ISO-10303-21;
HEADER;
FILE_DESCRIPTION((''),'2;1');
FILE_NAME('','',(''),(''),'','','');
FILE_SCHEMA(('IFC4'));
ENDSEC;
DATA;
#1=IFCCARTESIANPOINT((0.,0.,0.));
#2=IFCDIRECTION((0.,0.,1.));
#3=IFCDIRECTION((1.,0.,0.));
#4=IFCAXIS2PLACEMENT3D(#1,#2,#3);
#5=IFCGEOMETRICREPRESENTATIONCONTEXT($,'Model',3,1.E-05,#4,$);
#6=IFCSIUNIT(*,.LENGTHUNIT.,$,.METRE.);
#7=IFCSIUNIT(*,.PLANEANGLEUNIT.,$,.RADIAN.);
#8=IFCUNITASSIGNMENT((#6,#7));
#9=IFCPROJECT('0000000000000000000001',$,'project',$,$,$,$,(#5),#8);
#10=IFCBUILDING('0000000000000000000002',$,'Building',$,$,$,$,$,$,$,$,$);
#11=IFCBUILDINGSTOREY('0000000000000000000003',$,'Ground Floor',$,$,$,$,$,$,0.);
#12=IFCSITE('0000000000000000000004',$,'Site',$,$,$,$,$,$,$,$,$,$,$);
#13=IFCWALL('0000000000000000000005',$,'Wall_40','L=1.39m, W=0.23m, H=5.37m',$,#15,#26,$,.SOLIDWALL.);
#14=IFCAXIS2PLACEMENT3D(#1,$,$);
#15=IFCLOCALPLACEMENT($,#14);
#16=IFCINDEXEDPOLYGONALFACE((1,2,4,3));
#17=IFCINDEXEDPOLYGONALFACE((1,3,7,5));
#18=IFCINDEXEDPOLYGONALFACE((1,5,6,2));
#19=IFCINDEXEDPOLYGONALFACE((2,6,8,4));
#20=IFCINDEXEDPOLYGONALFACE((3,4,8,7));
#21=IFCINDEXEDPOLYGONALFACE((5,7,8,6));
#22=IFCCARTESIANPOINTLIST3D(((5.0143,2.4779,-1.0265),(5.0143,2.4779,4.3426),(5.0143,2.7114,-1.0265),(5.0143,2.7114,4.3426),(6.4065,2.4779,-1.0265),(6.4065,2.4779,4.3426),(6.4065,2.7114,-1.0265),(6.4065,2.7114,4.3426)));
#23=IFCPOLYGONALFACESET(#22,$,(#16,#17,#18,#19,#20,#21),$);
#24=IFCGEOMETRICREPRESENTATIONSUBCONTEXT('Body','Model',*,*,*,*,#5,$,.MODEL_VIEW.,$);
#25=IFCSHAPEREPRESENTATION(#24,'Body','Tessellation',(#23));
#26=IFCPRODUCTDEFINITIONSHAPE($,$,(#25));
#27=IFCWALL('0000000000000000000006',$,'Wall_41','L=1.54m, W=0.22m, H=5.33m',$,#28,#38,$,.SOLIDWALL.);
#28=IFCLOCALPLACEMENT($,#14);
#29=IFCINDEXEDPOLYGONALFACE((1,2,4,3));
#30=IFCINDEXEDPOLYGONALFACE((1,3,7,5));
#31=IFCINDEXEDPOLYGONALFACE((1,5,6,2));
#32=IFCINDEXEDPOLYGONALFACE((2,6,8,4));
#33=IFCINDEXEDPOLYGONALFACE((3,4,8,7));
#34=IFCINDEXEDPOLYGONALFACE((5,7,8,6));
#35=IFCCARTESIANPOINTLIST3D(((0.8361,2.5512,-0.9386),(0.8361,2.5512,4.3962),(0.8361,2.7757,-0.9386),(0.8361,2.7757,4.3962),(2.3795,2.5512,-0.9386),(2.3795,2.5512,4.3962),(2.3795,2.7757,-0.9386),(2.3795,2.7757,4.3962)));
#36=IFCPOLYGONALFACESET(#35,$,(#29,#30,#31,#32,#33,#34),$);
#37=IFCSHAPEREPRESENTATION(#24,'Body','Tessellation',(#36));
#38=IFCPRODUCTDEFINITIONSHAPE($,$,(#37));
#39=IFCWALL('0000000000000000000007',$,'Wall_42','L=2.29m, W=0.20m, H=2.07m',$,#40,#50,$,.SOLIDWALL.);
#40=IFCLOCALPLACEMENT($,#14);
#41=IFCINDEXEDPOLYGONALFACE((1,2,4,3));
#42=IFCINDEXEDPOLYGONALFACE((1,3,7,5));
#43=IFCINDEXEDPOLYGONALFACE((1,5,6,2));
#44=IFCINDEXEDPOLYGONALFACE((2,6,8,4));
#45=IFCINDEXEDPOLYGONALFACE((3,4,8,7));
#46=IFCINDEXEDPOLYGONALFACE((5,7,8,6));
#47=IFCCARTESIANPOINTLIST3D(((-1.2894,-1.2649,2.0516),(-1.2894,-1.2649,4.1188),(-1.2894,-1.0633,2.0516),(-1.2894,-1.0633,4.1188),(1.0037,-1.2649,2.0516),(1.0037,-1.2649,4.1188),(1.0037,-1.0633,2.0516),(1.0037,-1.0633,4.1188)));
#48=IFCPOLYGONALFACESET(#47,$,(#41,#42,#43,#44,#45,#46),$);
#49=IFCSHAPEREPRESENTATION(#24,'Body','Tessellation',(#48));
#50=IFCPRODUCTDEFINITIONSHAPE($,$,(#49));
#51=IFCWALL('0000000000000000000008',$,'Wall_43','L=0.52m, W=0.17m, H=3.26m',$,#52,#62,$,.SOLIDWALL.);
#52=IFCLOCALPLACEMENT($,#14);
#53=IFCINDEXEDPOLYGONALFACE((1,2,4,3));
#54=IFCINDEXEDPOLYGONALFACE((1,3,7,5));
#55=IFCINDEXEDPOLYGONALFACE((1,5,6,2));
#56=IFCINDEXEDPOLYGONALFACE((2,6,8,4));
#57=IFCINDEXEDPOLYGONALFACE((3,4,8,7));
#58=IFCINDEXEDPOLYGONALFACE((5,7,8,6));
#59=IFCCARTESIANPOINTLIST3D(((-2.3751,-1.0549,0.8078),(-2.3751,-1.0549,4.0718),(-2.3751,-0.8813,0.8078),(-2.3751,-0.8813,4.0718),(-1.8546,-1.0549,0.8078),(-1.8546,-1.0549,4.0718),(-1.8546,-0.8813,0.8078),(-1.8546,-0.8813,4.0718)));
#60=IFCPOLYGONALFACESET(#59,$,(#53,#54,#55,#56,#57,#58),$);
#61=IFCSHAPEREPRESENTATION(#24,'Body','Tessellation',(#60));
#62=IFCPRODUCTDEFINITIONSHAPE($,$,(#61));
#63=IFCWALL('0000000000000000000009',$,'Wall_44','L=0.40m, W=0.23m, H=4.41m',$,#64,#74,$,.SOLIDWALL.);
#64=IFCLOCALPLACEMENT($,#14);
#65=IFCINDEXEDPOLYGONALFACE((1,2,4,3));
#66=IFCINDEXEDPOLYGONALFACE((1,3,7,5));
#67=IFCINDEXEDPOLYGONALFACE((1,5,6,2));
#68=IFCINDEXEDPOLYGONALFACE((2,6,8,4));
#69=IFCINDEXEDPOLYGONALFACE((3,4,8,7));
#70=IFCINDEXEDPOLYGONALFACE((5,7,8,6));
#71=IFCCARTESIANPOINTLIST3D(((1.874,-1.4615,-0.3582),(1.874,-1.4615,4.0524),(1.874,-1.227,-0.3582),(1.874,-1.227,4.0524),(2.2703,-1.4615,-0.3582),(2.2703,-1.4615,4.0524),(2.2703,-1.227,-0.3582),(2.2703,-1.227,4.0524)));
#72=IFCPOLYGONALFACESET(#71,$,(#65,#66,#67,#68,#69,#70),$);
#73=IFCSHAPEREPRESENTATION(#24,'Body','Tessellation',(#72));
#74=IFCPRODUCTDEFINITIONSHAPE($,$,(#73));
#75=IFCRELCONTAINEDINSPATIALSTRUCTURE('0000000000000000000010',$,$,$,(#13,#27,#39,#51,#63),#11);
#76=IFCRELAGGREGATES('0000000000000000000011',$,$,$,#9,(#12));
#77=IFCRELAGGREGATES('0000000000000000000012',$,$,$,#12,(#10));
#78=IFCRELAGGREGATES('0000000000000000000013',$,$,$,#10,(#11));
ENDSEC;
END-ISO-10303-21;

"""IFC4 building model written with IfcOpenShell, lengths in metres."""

from ifc_helpers import new_model, si_unit, frame, origin_with_axes, origin_2d, context, subcontext, project, spatial, rectangle, extrude, element, save


model = new_model("IFC4")

# Units and contexts
model_context = context("Model", 3, precision=1e-05, world=origin_with_axes())
body_context = subcontext(model_context, "Body", "Model", "MODEL_VIEW")
ifc_project = project(units=[si_unit("LENGTHUNIT", "METRE"), si_unit("PLANEANGLEUNIT", "RADIAN")], contexts=[model_context])

# Site, building, storey
site = spatial("IfcSite", under=ifc_project, Name="Site")
building = spatial("IfcBuilding", under=site, Name="Building")
storey = spatial("IfcBuildingStorey", under=building, Name="Ground Floor", Elevation=0.0)

# Walls
element("IfcWall", 1, inside=storey, Name="Wall_40", Description="L=1.39m, W=0.23m, H=5.37m", PredefinedType="SOLIDWALL", context=body_context, shape_type="SweptSolid", body=[
    extrude(rectangle(XDim=1.3922, YDim=0.2334, at=origin_2d()), frame((5.7104, 2.5946, -1.0265), z_axis=(0.0, 0.0, 1.0), x_axis=(1.0, 0.0, 0.0)), (0.0, 0.0, 1.0), 5.369),
])
element("IfcWall", 2, inside=storey, Name="Wall_41", Description="L=1.54m, W=0.22m, H=5.33m", PredefinedType="SOLIDWALL", context=body_context, shape_type="SweptSolid", body=[
    extrude(rectangle(XDim=1.5434, YDim=0.2246, at=origin_2d()), frame((1.6078, 2.6634, -0.9386), z_axis=(0.0, 0.0, 1.0), x_axis=(1.0, 0.0, 0.0)), (0.0, 0.0, 1.0), 5.3348),
])
element("IfcWall", 3, inside=storey, Name="Wall_42", Description="L=2.29m, W=0.20m, H=2.07m", PredefinedType="SOLIDWALL", context=body_context, shape_type="SweptSolid", body=[
    extrude(rectangle(XDim=2.293, YDim=0.2016, at=origin_2d()), frame((-0.1429, -1.1641, 2.0516), z_axis=(0.0, 0.0, 1.0), x_axis=(1.0, 0.0, 0.0)), (0.0, 0.0, 1.0), 2.0672),
])
element("IfcWall", 4, inside=storey, Name="Wall_43", Description="L=0.52m, W=0.17m, H=3.26m", PredefinedType="SOLIDWALL", context=body_context, shape_type="SweptSolid", body=[
    extrude(rectangle(XDim=0.5205, YDim=0.1736, at=origin_2d()), frame((-2.1148, -0.9681, 0.8078), z_axis=(0.0, 0.0, 1.0), x_axis=(1.0, 0.0, 0.0)), (0.0, 0.0, 1.0), 3.264),
])
element("IfcWall", 5, inside=storey, Name="Wall_44", Description="L=0.40m, W=0.23m, H=4.41m", PredefinedType="SOLIDWALL", context=body_context, shape_type="SweptSolid", body=[
    extrude(rectangle(XDim=0.3962, YDim=0.2344, at=origin_2d()), frame((2.0721, -1.3442, -0.3582), z_axis=(0.0, 0.0, 1.0), x_axis=(1.0, 0.0, 0.0)), (0.0, 0.0, 1.0), 4.4106),
])

save(model, "model.ifc")
